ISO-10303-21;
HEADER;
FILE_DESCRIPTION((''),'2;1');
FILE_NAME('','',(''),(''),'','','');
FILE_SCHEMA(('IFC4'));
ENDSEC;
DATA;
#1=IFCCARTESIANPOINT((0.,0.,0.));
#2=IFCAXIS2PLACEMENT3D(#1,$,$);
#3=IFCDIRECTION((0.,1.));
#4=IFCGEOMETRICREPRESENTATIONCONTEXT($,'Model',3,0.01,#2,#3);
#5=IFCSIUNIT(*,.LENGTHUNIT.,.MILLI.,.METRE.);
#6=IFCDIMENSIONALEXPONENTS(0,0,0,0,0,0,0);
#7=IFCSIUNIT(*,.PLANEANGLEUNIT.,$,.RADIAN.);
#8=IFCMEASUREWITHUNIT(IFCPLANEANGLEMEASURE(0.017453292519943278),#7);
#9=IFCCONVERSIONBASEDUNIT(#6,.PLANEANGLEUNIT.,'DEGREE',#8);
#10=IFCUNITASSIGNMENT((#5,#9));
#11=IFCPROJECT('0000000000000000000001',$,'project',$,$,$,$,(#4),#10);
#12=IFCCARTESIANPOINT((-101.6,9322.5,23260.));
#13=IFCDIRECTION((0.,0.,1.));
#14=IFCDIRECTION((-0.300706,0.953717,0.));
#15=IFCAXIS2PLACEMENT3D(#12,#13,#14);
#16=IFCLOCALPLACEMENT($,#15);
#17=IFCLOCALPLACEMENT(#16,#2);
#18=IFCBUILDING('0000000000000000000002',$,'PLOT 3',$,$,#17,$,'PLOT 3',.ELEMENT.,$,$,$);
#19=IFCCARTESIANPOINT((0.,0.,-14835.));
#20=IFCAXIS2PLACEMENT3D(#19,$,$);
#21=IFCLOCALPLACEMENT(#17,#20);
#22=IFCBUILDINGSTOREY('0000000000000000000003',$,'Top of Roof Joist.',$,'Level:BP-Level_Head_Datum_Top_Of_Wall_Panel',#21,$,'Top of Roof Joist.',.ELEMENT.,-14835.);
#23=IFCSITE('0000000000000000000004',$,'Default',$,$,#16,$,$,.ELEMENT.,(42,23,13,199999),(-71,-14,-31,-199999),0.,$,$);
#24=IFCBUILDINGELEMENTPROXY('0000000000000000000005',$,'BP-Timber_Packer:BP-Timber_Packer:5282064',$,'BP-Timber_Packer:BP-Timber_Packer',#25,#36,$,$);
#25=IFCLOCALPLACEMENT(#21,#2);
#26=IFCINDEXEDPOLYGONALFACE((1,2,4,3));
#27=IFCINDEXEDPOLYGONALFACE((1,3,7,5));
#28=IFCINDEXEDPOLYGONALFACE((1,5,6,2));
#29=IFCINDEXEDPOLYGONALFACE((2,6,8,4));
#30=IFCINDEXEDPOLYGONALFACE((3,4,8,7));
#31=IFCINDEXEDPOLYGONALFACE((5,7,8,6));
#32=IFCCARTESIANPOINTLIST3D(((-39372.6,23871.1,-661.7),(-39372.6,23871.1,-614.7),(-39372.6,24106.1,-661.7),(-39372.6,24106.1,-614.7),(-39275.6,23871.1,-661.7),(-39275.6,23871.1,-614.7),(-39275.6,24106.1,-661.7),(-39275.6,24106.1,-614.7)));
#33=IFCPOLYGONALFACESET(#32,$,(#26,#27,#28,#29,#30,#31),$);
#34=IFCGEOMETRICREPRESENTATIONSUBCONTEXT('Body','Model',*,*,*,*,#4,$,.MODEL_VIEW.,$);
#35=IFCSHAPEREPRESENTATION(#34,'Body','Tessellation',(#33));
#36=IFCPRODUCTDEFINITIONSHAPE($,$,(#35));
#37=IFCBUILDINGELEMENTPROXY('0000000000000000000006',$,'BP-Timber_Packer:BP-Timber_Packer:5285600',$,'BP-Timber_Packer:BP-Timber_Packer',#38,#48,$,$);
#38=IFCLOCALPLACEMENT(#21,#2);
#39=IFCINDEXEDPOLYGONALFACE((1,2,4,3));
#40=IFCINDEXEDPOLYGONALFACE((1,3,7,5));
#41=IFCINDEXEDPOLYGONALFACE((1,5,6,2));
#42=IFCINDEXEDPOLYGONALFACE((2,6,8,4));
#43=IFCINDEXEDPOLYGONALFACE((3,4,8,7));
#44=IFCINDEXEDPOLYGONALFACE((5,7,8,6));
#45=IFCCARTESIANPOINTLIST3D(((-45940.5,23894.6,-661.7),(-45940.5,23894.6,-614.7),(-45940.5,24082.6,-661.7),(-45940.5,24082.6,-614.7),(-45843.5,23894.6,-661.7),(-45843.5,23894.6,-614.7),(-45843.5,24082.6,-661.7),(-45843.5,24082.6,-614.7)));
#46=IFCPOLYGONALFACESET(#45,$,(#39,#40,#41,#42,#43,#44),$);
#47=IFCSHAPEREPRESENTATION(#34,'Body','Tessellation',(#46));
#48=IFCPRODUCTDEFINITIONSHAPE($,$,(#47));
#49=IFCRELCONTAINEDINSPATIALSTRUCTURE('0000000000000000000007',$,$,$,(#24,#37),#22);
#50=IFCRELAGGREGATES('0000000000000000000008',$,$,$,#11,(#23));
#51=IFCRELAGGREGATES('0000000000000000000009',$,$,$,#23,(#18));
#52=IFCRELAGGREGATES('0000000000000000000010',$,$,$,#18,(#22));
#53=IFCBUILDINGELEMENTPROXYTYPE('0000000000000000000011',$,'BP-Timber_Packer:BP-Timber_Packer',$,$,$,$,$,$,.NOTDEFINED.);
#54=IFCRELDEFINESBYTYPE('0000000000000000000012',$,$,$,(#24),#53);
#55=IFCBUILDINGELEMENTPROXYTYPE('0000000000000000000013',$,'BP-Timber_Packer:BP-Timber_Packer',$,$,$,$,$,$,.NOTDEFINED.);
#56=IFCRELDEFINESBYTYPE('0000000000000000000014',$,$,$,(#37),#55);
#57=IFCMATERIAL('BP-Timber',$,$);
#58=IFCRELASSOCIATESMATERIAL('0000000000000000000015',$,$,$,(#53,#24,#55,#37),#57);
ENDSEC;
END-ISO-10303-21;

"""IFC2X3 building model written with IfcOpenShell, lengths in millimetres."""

from ifc_helpers import new_model, entity, si_unit, converted_unit, direction, frame, origin, origin_2d_with_axis, place, context, subcontext, project, spatial, rectangle, extrude, source, transform, mapped, material, type_object, type_shapes, element, save


model = new_model("IFC2X3")

# Units and contexts
model_context = context("Model", 3, precision=0.01, world=origin(), true_north=direction((0.0, 1.0)))
body_context = subcontext(model_context, "Body", "Model", "MODEL_VIEW")
ifc_project = project(units=[si_unit("LENGTHUNIT", "METRE", prefix="MILLI"), converted_unit("PLANEANGLEUNIT", "DEGREE", entity("IfcPlaneAngleMeasure", 0.017453292519943278), si_unit("PLANEANGLEUNIT", "RADIAN"), dimensions=[0, 0, 0, 0, 0, 0, 0])], contexts=[model_context])

# Site, building, storey
site_placement = place(None, frame((-101.6, 9322.5, 23260.0), z_axis=(0.0, 0.0, 1.0), x_axis=(-0.300706, 0.953717, 0.0)))
site = spatial("IfcSite", under=ifc_project, at=site_placement, Name="Default", CompositionType="ELEMENT", RefLatitude=(42, 23, 13, 199999), RefLongitude=(-71, -14, -31, -199999), RefElevation=0.0)
building_placement = place(site_placement, origin())
building = spatial("IfcBuilding", under=site, at=building_placement, Name="PLOT 3", LongName="PLOT 3", CompositionType="ELEMENT")
storey_placement = place(building_placement, frame((0.0, 0.0, -14835.0)))
storey = spatial("IfcBuildingStorey", under=building, at=storey_placement, Name="Top of Roof Joist.", ObjectType="Level:BP-Level_Head_Datum_Top_Of_Wall_Panel", LongName="Top of Roof Joist.", CompositionType="ELEMENT", Elevation=-14835.0)

# Building element proxies
ifc_material = material(Name="BP-Timber")
building_element_proxy_type_1 = type_object("IfcBuildingElementProxyType", Name="BP-Timber_Packer:BP-Timber_Packer", PredefinedType="NOTDEFINED", material=ifc_material)
shared_shape_1 = source(origin(), body_context, "Body", "SweptSolid", [
    extrude(rectangle(XDim=235.0, YDim=97.0, at=origin_2d_with_axis()), frame((0.0, 0.0, 0.0), z_axis=(0.0, 0.0, 1.0), x_axis=(-1.0, 0.0, 0.0)), (0.0, 0.0, 1.0), 47.0),
])
type_shapes(building_element_proxy_type_1, [shared_shape_1])
proxy_1_placement = place(storey_placement, frame((-39324.1, 23988.6, -661.7), z_axis=(0.0, 0.0, 1.0), x_axis=(0.0, -1.0, 0.0)))
element("IfcBuildingElementProxy", 1, at=proxy_1_placement, inside=storey, type_object=building_element_proxy_type_1, material=ifc_material, Name="BP-Timber_Packer:BP-Timber_Packer:5282064", ObjectType="BP-Timber_Packer:BP-Timber_Packer", context=body_context, shape_type="MappedRepresentation", body=[
    mapped(shared_shape_1, transform((0.0, 0.0, 0.0), scale=1.0)),
])
building_element_proxy_type_2 = type_object("IfcBuildingElementProxyType", Name="BP-Timber_Packer:BP-Timber_Packer", PredefinedType="NOTDEFINED", material=ifc_material)
shared_shape_2 = source(origin(), body_context, "Body", "SweptSolid", [
    extrude(rectangle(XDim=97.0, YDim=188.0, at=origin_2d_with_axis()), frame((0.0, 0.0, 0.0), z_axis=(0.0, 0.0, 1.0), x_axis=(0.0, 1.0, 0.0)), (0.0, 0.0, 1.0), 47.0),
])
type_shapes(building_element_proxy_type_2, [shared_shape_2])
proxy_2_placement = place(storey_placement, frame((-45892.0, 23988.6, -661.7), z_axis=(0.0, 0.0, 1.0), x_axis=(0.0, 1.0, 0.0)))
element("IfcBuildingElementProxy", 2, at=proxy_2_placement, inside=storey, type_object=building_element_proxy_type_2, material=ifc_material, Name="BP-Timber_Packer:BP-Timber_Packer:5285600", ObjectType="BP-Timber_Packer:BP-Timber_Packer", context=body_context, shape_type="MappedRepresentation", body=[
    mapped(shared_shape_2, transform((0.0, 0.0, 0.0), scale=1.0)),
])

save(model, "model.ifc")
